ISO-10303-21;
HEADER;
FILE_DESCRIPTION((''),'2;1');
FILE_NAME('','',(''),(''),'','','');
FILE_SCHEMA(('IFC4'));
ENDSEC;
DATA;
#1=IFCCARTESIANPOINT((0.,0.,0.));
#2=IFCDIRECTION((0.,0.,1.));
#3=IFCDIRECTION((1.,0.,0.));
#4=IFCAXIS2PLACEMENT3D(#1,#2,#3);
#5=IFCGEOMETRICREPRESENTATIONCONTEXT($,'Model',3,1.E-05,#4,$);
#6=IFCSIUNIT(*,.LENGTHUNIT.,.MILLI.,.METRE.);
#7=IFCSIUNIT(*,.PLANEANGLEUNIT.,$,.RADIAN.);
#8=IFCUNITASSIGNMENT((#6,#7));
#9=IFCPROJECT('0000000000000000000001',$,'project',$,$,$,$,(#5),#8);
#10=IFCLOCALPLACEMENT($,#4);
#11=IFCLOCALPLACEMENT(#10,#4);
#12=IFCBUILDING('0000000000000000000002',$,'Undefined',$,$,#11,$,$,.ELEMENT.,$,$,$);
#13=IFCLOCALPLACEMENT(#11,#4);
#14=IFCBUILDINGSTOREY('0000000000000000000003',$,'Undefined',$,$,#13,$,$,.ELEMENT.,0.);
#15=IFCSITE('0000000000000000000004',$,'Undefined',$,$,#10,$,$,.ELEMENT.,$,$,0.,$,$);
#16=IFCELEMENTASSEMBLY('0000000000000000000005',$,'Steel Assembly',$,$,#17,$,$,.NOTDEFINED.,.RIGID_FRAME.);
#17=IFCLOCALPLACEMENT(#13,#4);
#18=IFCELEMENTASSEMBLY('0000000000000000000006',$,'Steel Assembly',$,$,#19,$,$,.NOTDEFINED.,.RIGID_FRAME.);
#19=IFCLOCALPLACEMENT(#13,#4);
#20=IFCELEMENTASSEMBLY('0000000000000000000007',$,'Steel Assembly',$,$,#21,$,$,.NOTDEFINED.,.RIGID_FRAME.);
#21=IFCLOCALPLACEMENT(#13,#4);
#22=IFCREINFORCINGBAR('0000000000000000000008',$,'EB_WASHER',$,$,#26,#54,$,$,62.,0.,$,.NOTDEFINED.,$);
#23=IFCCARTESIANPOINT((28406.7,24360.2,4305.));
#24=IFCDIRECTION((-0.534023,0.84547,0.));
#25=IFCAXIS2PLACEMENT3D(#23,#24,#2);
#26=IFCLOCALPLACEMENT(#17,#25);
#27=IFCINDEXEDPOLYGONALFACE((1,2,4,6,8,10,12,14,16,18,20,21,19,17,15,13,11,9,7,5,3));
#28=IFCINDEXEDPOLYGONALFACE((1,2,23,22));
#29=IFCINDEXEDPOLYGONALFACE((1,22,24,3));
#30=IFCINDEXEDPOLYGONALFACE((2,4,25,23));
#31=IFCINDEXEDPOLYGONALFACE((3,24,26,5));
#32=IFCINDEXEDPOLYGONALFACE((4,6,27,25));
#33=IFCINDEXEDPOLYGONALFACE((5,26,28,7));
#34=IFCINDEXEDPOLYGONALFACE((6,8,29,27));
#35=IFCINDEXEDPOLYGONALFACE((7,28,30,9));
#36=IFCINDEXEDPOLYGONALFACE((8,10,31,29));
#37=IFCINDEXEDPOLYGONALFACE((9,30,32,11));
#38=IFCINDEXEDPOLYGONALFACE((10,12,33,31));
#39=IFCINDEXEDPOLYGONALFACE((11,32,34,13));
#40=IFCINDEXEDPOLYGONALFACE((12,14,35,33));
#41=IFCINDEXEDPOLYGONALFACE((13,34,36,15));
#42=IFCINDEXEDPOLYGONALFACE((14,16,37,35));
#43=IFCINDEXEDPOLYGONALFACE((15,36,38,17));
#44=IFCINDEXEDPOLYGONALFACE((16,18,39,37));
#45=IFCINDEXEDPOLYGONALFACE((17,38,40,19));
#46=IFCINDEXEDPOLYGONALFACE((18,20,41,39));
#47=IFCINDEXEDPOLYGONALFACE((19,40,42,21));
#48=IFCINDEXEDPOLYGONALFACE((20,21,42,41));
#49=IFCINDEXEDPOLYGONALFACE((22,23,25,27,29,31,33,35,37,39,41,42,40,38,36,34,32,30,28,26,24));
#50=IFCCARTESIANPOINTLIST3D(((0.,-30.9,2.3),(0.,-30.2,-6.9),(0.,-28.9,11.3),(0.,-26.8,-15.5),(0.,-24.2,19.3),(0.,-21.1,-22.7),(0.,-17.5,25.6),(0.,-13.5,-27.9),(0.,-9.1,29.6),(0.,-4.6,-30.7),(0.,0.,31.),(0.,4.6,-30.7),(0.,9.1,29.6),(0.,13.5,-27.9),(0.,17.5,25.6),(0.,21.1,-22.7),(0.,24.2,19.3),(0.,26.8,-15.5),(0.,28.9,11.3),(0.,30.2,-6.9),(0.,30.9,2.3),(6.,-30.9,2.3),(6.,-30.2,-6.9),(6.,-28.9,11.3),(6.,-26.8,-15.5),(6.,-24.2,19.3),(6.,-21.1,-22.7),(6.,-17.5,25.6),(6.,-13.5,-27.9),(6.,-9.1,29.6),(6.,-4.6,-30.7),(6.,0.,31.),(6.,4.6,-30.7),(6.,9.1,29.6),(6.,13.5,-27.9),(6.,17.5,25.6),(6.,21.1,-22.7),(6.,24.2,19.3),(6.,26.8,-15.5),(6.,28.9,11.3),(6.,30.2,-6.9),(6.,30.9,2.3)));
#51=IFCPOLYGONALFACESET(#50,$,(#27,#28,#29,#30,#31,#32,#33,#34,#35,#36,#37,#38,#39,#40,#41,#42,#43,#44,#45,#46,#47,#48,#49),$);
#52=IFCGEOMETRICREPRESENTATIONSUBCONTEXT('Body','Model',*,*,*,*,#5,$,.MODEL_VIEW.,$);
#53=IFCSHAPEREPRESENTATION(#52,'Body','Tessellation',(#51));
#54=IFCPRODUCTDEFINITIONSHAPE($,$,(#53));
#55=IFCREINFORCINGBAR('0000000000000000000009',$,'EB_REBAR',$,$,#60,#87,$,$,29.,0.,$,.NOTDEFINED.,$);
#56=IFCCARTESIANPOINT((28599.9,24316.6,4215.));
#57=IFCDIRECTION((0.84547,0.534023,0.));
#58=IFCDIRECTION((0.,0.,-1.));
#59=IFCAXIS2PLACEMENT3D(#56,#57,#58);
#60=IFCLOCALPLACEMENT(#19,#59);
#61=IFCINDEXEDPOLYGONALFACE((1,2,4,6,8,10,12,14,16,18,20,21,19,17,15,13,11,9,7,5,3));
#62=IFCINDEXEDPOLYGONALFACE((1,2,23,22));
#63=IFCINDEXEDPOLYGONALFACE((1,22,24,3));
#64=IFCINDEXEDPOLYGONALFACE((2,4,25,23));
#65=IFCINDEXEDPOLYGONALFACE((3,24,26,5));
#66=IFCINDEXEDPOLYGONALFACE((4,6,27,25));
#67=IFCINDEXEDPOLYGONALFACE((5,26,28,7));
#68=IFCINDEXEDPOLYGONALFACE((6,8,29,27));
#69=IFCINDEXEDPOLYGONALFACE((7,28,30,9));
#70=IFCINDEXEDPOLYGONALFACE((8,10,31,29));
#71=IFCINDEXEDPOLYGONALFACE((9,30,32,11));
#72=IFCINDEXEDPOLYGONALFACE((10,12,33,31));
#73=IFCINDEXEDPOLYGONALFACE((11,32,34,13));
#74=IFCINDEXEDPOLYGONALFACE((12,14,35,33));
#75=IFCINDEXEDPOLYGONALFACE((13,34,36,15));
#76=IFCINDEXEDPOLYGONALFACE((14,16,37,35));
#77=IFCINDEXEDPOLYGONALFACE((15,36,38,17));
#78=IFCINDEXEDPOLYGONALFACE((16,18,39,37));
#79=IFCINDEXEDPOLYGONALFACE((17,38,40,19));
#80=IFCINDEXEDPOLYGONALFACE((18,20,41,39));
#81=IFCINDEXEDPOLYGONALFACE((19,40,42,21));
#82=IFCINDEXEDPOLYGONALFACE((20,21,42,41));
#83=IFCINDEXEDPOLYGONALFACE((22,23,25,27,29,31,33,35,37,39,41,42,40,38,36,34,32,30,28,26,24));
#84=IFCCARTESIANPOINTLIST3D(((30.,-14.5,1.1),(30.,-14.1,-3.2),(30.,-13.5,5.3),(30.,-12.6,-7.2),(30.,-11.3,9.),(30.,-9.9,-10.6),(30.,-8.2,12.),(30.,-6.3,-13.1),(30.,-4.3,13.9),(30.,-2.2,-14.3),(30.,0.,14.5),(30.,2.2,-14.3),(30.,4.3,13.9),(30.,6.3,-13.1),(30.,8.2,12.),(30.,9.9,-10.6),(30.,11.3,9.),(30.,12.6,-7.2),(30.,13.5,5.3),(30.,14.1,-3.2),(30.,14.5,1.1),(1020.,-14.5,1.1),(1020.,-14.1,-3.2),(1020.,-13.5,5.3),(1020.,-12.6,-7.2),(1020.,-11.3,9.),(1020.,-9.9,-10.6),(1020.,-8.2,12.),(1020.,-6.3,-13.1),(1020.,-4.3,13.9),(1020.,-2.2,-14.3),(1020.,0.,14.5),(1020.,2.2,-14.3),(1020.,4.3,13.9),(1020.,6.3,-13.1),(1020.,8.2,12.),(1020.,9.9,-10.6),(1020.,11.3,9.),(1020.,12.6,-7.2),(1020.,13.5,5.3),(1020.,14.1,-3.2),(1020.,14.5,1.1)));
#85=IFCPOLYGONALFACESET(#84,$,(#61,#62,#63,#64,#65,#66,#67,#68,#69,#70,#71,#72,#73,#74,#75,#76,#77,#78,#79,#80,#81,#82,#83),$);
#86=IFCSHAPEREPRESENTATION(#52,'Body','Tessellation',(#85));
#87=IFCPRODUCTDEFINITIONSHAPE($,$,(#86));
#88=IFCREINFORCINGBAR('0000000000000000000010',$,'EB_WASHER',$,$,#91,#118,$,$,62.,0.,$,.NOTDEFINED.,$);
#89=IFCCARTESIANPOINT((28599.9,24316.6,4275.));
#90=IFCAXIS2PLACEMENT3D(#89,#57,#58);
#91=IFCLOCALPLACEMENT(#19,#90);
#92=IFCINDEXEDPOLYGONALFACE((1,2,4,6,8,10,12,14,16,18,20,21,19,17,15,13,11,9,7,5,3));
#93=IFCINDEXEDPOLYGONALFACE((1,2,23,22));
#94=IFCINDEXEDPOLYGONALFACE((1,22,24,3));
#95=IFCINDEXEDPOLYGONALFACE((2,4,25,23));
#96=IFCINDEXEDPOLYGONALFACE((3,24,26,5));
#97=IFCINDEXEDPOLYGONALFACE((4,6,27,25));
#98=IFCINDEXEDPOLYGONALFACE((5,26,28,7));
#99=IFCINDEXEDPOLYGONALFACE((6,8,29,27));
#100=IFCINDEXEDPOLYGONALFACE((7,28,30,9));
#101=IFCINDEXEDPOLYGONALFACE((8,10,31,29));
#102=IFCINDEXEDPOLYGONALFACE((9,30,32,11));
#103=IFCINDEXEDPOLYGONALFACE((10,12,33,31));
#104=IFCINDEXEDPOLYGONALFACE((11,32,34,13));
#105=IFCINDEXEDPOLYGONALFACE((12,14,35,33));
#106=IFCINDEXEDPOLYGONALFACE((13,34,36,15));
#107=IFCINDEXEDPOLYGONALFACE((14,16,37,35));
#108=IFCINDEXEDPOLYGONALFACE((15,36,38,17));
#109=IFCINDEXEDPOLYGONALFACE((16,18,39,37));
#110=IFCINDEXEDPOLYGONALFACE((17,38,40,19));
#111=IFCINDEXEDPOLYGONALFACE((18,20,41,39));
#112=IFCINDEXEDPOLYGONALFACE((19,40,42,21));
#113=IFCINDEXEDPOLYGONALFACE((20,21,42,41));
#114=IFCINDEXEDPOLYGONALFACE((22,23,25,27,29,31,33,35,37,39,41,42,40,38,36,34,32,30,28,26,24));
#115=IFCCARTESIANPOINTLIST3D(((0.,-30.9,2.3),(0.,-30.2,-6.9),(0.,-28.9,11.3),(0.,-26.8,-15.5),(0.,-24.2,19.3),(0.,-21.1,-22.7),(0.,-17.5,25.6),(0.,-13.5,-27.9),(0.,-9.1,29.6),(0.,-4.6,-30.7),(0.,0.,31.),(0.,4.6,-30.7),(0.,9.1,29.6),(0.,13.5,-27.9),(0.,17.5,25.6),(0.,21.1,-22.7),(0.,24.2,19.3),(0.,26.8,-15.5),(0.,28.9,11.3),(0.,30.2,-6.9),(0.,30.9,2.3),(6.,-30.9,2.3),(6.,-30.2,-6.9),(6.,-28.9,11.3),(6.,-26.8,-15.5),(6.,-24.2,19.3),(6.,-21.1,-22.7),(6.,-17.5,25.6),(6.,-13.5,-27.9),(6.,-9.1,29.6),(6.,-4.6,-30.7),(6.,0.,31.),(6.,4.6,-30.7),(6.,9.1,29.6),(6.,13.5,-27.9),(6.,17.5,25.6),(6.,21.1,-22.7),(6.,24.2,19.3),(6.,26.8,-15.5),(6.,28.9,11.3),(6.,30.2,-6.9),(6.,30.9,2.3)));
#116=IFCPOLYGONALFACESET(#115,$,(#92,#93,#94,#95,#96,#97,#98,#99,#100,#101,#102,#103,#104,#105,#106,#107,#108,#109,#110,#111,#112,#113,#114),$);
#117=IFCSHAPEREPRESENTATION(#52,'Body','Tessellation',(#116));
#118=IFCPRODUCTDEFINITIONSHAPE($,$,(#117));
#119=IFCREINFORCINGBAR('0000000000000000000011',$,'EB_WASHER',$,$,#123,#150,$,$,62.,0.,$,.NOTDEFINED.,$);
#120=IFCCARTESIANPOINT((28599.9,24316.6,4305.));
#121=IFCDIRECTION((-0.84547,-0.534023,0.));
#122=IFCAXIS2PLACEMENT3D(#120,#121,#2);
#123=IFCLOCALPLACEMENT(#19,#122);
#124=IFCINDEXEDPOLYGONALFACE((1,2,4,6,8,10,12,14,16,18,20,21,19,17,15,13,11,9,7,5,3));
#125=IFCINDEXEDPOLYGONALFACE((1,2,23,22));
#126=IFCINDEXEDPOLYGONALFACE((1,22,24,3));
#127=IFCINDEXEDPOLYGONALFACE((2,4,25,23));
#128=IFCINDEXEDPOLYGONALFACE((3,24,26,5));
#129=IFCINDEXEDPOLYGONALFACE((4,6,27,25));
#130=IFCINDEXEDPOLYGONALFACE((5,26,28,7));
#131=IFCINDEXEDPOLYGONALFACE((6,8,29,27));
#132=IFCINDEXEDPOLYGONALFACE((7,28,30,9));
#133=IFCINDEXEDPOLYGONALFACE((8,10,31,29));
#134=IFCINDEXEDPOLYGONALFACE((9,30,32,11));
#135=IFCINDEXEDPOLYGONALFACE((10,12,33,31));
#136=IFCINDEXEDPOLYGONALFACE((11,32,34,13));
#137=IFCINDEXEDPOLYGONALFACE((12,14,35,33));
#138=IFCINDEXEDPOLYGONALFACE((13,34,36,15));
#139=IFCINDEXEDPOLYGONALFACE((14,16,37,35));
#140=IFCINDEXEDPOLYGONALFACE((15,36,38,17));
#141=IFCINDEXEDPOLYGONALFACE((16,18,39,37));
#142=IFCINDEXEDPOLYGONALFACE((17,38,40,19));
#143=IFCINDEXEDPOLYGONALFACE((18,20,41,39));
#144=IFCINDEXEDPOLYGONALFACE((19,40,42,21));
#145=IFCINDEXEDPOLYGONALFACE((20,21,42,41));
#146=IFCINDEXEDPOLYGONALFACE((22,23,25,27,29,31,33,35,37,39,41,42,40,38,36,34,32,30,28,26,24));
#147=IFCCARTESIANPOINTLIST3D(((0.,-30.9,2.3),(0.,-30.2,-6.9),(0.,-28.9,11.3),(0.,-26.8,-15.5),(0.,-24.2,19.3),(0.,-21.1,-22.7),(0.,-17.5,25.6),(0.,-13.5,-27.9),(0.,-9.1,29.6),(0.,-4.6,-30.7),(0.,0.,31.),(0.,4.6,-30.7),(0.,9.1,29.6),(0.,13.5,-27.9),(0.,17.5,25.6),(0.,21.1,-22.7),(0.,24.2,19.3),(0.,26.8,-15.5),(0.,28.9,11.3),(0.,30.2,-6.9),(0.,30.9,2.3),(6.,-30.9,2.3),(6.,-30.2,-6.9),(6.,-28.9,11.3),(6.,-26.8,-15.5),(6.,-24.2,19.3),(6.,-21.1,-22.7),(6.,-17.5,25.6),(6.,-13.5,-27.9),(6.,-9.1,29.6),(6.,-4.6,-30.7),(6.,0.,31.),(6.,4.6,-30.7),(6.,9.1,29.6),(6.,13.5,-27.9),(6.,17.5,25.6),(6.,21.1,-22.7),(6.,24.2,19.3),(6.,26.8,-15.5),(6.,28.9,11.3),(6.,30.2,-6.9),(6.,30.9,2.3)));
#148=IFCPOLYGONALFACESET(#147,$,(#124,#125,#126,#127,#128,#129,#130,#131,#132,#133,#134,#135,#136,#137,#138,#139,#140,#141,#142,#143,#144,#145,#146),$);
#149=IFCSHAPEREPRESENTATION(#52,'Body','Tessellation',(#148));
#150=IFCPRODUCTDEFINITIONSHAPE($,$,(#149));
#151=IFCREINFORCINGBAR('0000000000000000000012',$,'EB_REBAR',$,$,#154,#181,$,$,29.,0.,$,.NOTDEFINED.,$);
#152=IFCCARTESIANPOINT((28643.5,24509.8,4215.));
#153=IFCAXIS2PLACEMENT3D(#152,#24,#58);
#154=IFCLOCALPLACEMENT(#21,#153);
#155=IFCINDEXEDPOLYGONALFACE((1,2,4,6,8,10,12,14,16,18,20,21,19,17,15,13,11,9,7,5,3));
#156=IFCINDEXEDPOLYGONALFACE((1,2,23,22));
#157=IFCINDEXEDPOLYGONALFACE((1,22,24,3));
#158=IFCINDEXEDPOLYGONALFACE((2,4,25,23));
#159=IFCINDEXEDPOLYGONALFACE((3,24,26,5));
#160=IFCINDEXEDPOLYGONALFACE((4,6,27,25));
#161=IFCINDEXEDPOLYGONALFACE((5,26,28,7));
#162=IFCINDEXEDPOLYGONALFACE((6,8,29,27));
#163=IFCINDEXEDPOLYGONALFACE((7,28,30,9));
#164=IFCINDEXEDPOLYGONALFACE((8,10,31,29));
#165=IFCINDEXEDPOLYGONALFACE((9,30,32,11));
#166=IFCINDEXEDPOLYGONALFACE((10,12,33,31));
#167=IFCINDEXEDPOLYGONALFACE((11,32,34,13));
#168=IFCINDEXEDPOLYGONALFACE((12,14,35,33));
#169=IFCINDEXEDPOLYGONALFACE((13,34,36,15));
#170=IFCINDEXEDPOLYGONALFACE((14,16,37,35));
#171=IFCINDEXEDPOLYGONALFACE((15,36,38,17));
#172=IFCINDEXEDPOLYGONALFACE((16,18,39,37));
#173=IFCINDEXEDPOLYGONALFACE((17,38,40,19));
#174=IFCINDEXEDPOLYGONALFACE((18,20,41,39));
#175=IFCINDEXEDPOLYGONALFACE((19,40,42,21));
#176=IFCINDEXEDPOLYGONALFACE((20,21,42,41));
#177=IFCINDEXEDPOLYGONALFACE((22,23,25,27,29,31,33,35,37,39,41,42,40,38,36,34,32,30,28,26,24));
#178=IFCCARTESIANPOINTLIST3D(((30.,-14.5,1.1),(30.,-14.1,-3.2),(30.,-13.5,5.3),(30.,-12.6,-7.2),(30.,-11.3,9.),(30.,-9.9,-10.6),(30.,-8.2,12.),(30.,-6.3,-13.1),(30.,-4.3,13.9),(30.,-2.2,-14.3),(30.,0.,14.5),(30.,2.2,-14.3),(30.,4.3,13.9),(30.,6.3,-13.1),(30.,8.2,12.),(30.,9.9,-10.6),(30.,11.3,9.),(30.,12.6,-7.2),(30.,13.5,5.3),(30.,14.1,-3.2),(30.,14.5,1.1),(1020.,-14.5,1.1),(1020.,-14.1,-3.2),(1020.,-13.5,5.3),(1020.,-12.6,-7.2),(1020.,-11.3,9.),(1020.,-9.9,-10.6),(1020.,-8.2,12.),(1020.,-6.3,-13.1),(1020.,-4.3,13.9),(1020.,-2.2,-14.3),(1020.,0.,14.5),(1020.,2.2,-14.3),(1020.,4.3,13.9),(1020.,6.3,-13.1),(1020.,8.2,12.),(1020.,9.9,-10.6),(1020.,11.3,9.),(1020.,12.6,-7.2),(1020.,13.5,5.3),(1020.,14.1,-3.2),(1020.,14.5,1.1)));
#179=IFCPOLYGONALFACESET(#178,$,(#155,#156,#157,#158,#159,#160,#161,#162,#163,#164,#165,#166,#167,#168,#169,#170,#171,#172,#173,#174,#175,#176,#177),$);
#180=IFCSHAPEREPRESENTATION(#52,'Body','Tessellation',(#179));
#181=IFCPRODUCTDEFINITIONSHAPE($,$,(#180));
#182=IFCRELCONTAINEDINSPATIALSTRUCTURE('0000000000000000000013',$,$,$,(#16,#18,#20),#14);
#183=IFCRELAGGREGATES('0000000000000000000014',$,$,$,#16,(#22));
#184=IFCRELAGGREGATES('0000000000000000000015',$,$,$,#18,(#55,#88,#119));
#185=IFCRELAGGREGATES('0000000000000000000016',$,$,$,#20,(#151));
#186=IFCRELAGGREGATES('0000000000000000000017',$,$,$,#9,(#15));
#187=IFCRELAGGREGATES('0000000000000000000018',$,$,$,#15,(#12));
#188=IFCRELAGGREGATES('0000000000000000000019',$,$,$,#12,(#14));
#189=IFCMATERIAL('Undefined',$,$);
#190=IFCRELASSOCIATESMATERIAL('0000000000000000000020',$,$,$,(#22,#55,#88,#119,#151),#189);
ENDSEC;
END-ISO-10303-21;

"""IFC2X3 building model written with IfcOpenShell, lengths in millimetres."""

from ifc_helpers import new_model, entity, si_unit, frame, origin_with_axes, place, context, subcontext, project, spatial, source, transform, mapped, material, element, aggregate, save


model = new_model("IFC2X3")

# Units and contexts
model_context = context("Model", 3, precision=1e-05, world=origin_with_axes())
body_context = subcontext(model_context, "Body", "Model", "MODEL_VIEW")
ifc_project = project(units=[si_unit("LENGTHUNIT", "METRE", prefix="MILLI"), si_unit("PLANEANGLEUNIT", "RADIAN")], contexts=[model_context])

# Site, building, storey
site_placement = place(None, origin_with_axes())
site = spatial("IfcSite", under=ifc_project, at=site_placement, Name="Undefined", CompositionType="ELEMENT", RefElevation=0.0)
building_placement = place(site_placement, origin_with_axes())
building = spatial("IfcBuilding", under=site, at=building_placement, Name="Undefined", CompositionType="ELEMENT")
storey_placement = place(building_placement, origin_with_axes())
storey = spatial("IfcBuildingStorey", under=building, at=storey_placement, Name="Undefined", CompositionType="ELEMENT", Elevation=0.0)

# Element assemblies
assembly_1_placement = place(storey_placement, origin_with_axes())
assembly_1 = element("IfcElementAssembly", 1, at=assembly_1_placement, inside=storey, Name="Steel Assembly", AssemblyPlace="NOTDEFINED", PredefinedType="RIGID_FRAME")
assembly_2_placement = place(storey_placement, origin_with_axes())
assembly_2 = element("IfcElementAssembly", 2, at=assembly_2_placement, inside=storey, Name="Steel Assembly", AssemblyPlace="NOTDEFINED", PredefinedType="RIGID_FRAME")
assembly_3_placement = place(storey_placement, origin_with_axes())
assembly_3 = element("IfcElementAssembly", 3, at=assembly_3_placement, inside=storey, Name="Steel Assembly", AssemblyPlace="NOTDEFINED", PredefinedType="RIGID_FRAME")

# Shared definitions
ifc_material_1 = material(Name="Undefined")

# Reinforcing bars
shared_shape_1 = source(origin_with_axes(), body_context, "Body", "AdvancedSweptSolid", [
    entity("IfcSweptDiskSolid", entity("IfcTrimmedCurve", entity("IfcLine", entity("IfcCartesianPoint", [0.0, 0.0, 0.0]), entity("IfcVector", entity("IfcDirection", [1.0, 0.0, 0.0]), 1.0)), [entity("IfcParameterValue", 0.0)], [entity("IfcParameterValue", 6.0)], True, "PARAMETER"), 31.0, None, 0.0, 6.0),
])
reinforcing_bar_1_placement = place(assembly_1_placement, frame((28406.7, 24360.2, 4305.0), z_axis=(-0.534023, 0.84547, 0.0), x_axis=(0.0, 0.0, 1.0)))
reinforcing_bar_1 = element("IfcReinforcingBar", 4, at=reinforcing_bar_1_placement, material=ifc_material_1, Name="EB_WASHER", BarRole="NOTDEFINED", CrossSectionArea=0.0, NominalDiameter=62.0, context=body_context, shape_type="MappedRepresentation", body=[
    mapped(shared_shape_1, transform((0.0, 0.0, 0.0))),
])
aggregate(assembly_1, [reinforcing_bar_1])
shared_shape_2 = source(origin_with_axes(), body_context, "Body", "AdvancedSweptSolid", [
    entity("IfcSweptDiskSolid", entity("IfcTrimmedCurve", entity("IfcLine", entity("IfcCartesianPoint", [0.0, 0.0, 0.0]), entity("IfcVector", entity("IfcDirection", [1.0, 0.0, 0.0]), 1.0)), [entity("IfcParameterValue", 0.0)], [entity("IfcParameterValue", 990.0)], True, "PARAMETER"), 14.5, None, 0.0, 990.0),
])
reinforcing_bar_2_placement = place(assembly_2_placement, frame((28599.9, 24316.6, 4215.0), z_axis=(0.84547, 0.534023, 0.0), x_axis=(0.0, 0.0, -1.0)))
reinforcing_bar_2 = element("IfcReinforcingBar", 5, at=reinforcing_bar_2_placement, material=ifc_material_1, Name="EB_REBAR", BarRole="NOTDEFINED", CrossSectionArea=0.0, NominalDiameter=29.0, context=body_context, shape_type="MappedRepresentation", body=[
    mapped(shared_shape_2, transform((30.0, 0.0, 0.0))),
])
shared_shape_3 = source(origin_with_axes(), body_context, "Body", "AdvancedSweptSolid", [
    entity("IfcSweptDiskSolid", entity("IfcTrimmedCurve", entity("IfcLine", entity("IfcCartesianPoint", [0.0, 0.0, 0.0]), entity("IfcVector", entity("IfcDirection", [1.0, 0.0, 0.0]), 1.0)), [entity("IfcParameterValue", 0.0)], [entity("IfcParameterValue", 6.0)], True, "PARAMETER"), 31.0, None, 0.0, 6.0),
])
reinforcing_bar_3_placement = place(assembly_2_placement, frame((28599.9, 24316.6, 4275.0), z_axis=(0.84547, 0.534023, 0.0), x_axis=(0.0, 0.0, -1.0)))
reinforcing_bar_3 = element("IfcReinforcingBar", 6, at=reinforcing_bar_3_placement, material=ifc_material_1, Name="EB_WASHER", BarRole="NOTDEFINED", CrossSectionArea=0.0, NominalDiameter=62.0, context=body_context, shape_type="MappedRepresentation", body=[
    mapped(shared_shape_3, transform((0.0, 0.0, 0.0))),
])
shared_shape_4 = source(origin_with_axes(), body_context, "Body", "AdvancedSweptSolid", [
    entity("IfcSweptDiskSolid", entity("IfcTrimmedCurve", entity("IfcLine", entity("IfcCartesianPoint", [0.0, 0.0, 0.0]), entity("IfcVector", entity("IfcDirection", [1.0, 0.0, 0.0]), 1.0)), [entity("IfcParameterValue", 0.0)], [entity("IfcParameterValue", 6.0)], True, "PARAMETER"), 31.0, None, 0.0, 6.0),
])
reinforcing_bar_4_placement = place(assembly_2_placement, frame((28599.9, 24316.6, 4305.0), z_axis=(-0.84547, -0.534023, 0.0), x_axis=(0.0, 0.0, 1.0)))
reinforcing_bar_4 = element("IfcReinforcingBar", 7, at=reinforcing_bar_4_placement, material=ifc_material_1, Name="EB_WASHER", BarRole="NOTDEFINED", CrossSectionArea=0.0, NominalDiameter=62.0, context=body_context, shape_type="MappedRepresentation", body=[
    mapped(shared_shape_4, transform((0.0, 0.0, 0.0))),
])
aggregate(assembly_2, [reinforcing_bar_2, reinforcing_bar_3, reinforcing_bar_4])
shared_shape_5 = source(origin_with_axes(), body_context, "Body", "AdvancedSweptSolid", [
    entity("IfcSweptDiskSolid", entity("IfcTrimmedCurve", entity("IfcLine", entity("IfcCartesianPoint", [0.0, 0.0, 0.0]), entity("IfcVector", entity("IfcDirection", [1.0, 0.0, 0.0]), 1.0)), [entity("IfcParameterValue", 0.0)], [entity("IfcParameterValue", 990.0)], True, "PARAMETER"), 14.5, None, 0.0, 990.0),
])
reinforcing_bar_5_placement = place(assembly_3_placement, frame((28643.5, 24509.8, 4215.0), z_axis=(-0.534023, 0.84547, 0.0), x_axis=(0.0, 0.0, -1.0)))
reinforcing_bar_5 = element("IfcReinforcingBar", 8, at=reinforcing_bar_5_placement, material=ifc_material_1, Name="EB_REBAR", BarRole="NOTDEFINED", CrossSectionArea=0.0, NominalDiameter=29.0, context=body_context, shape_type="MappedRepresentation", body=[
    mapped(shared_shape_5, transform((30.0, 0.0, 0.0))),
])
aggregate(assembly_3, [reinforcing_bar_5])

save(model, "model.ifc")
